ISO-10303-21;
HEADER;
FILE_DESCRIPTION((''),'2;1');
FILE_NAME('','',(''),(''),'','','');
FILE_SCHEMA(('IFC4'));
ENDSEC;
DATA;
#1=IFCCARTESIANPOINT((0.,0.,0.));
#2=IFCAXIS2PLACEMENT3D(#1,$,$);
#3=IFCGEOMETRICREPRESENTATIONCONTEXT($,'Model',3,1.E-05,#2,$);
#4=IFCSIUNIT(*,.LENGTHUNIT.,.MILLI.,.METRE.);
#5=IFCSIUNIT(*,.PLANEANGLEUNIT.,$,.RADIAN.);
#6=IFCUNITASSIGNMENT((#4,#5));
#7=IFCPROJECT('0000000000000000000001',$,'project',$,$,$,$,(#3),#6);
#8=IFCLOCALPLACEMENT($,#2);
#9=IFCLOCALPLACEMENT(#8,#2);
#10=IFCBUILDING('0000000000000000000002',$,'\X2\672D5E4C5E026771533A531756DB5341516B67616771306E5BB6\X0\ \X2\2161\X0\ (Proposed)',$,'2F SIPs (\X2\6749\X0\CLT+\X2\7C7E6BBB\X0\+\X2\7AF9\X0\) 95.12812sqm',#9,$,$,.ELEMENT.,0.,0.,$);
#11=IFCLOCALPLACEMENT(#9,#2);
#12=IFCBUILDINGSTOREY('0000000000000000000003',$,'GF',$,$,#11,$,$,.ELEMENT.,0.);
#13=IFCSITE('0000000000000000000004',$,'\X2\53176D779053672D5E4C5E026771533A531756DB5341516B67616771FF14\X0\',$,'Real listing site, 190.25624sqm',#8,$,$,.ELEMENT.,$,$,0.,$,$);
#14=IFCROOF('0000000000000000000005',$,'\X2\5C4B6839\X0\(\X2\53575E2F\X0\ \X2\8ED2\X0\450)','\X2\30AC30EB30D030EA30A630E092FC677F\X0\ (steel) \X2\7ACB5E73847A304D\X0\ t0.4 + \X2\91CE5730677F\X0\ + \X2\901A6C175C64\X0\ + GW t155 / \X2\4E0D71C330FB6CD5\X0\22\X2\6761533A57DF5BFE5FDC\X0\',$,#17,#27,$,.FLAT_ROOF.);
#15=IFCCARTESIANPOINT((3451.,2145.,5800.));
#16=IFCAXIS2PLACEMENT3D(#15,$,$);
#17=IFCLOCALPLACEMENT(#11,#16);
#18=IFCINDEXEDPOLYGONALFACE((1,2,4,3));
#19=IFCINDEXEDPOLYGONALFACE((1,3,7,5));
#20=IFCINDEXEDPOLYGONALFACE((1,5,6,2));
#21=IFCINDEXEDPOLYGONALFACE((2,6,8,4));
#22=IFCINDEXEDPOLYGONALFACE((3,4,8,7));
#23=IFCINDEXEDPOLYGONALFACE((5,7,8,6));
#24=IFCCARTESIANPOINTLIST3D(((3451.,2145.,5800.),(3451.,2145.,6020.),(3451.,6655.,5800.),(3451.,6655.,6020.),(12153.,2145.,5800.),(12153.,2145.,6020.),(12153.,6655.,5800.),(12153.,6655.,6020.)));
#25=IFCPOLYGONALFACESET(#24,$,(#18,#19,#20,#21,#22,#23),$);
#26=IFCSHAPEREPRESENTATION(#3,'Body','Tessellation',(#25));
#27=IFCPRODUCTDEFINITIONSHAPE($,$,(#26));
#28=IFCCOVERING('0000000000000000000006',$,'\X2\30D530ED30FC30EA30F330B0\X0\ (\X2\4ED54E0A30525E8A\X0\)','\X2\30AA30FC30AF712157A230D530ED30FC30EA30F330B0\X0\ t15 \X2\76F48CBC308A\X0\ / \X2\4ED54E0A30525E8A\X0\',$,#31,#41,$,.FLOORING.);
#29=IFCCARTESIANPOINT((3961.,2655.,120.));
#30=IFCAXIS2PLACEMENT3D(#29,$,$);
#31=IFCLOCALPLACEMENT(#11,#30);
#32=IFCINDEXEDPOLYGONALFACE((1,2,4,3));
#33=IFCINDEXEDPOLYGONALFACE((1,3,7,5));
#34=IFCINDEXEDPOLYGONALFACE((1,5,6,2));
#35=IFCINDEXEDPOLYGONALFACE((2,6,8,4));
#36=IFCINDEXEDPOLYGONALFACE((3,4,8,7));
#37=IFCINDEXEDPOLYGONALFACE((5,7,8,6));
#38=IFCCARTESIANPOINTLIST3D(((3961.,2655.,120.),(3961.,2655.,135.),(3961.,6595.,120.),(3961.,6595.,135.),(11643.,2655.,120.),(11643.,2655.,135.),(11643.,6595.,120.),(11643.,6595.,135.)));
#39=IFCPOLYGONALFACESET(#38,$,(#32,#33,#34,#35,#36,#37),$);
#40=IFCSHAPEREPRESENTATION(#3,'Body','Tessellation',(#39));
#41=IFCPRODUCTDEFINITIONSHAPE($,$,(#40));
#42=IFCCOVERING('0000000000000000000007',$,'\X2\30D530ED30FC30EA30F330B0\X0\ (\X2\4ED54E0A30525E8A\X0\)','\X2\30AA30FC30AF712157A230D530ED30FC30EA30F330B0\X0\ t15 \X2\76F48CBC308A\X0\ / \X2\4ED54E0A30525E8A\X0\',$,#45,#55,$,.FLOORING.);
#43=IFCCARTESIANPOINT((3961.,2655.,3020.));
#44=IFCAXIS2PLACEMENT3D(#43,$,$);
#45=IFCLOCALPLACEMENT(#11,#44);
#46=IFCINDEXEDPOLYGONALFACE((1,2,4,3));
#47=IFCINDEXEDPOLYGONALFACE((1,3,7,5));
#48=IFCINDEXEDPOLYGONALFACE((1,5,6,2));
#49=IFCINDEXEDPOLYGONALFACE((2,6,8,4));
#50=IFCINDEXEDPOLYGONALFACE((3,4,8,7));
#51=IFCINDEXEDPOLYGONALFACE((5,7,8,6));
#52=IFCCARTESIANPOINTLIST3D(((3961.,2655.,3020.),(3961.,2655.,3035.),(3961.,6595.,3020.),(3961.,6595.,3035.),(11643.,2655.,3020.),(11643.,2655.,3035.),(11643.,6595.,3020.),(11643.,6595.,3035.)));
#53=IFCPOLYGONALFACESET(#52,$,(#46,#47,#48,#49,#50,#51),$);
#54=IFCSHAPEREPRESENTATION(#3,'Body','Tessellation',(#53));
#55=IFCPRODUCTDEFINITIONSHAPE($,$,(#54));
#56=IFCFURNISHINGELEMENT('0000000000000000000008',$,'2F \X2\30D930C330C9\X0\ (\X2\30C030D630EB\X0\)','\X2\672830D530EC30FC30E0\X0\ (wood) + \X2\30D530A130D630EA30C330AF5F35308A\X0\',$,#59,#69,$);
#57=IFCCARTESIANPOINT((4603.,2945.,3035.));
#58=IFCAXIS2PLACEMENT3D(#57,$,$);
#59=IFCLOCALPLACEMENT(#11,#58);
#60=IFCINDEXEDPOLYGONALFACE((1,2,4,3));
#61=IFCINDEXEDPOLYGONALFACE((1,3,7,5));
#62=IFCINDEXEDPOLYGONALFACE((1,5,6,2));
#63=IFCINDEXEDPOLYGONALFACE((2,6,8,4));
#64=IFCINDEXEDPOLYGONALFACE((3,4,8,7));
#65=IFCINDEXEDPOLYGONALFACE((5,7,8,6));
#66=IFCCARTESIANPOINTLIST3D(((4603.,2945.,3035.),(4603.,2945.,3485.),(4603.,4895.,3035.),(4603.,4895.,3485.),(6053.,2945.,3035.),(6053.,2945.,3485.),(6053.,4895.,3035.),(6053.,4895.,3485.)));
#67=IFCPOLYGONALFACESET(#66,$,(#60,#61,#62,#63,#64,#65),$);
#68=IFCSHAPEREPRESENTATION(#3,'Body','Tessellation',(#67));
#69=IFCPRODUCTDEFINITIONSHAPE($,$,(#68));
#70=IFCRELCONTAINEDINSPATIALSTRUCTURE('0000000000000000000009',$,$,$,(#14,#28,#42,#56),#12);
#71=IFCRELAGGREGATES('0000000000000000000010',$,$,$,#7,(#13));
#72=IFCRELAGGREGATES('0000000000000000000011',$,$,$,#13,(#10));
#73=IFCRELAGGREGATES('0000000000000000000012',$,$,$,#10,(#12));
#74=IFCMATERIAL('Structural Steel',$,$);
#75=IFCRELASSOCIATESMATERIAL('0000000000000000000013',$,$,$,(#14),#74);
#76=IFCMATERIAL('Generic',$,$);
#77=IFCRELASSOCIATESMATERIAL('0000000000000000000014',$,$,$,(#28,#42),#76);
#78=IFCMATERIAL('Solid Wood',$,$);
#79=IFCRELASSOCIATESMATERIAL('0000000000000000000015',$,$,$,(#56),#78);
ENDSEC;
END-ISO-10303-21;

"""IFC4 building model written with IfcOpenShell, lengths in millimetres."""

from ifc_helpers import new_model, si_unit, frame, frame_2d, origin, place, context, project, spatial, rectangle, extrude, material, element, save


model = new_model("IFC4")

# Units and contexts
model_context = context("Model", 3, precision=1e-05, world=origin())
ifc_project = project(units=[si_unit("LENGTHUNIT", "METRE", prefix="MILLI"), si_unit("PLANEANGLEUNIT", "RADIAN")], contexts=[model_context])

# Site, building, storey
site_placement = place(None, origin())
site = spatial("IfcSite", under=ifc_project, at=site_placement, Name="北海道札幌市東区北四十八条東４", ObjectType="Real listing site, 190.25624sqm", CompositionType="ELEMENT", RefElevation=0.0)
building_placement = place(site_placement, origin())
building = spatial("IfcBuilding", under=site, at=building_placement, Name="札幌市東区北四十八条東の家 Ⅱ (Proposed)", ObjectType="2F SIPs (杉CLT+籾殻+竹) 95.12812sqm", CompositionType="ELEMENT", ElevationOfRefHeight=0.0, ElevationOfTerrain=0.0)
storey_placement = place(building_placement, origin())
storey = spatial("IfcBuildingStorey", under=building, at=storey_placement, Name="GF", CompositionType="ELEMENT", Elevation=0.0)

# Shared definitions
ifc_material_1 = material(Name="Solid Wood")

# Roof
ifc_material_2 = material(Name="Structural Steel")
for number, where, name in (
    (1, (3451.0, 2145.0, 5800.0), "屋根(南帯 軒450)"),
):
    element("IfcRoof", number, at=place(storey_placement, frame(where)), inside=storey, material=ifc_material_2, Name=name, Description="ガルバリウム鋼板 (steel) 立平葺き t0.4 + 野地板 + 通気層 + GW t155 / 不燃・法22条区域対応", PredefinedType="FLAT_ROOF", context=model_context, shape_type="SweptSolid", body=[
        extrude(rectangle(XDim=8702.0, YDim=4510.0, at=frame_2d((4351.0, 2255.0))), frame((3451.0, 2145.0, 5800.0)), (0.0, 0.0, 1.0), 220.0),
    ])

# Coverings
ifc_material_3 = material(Name="Generic")
covering_1_placement = place(storey_placement, frame((3961.0, 2655.0, 120.0)))
element("IfcCovering", 2, at=covering_1_placement, inside=storey, material=ifc_material_3, Name="フローリング (仕上げ床)", Description="オーク無垢フローリング t15 直貼り / 仕上げ床", PredefinedType="FLOORING", context=model_context, shape_type="SweptSolid", body=[
    extrude(rectangle(XDim=7682.0, YDim=3940.0, at=frame_2d((3841.0, 1970.0))), frame((3961.0, 2655.0, 120.0)), (0.0, 0.0, 1.0), 15.0),
])
covering_2_placement = place(storey_placement, frame((3961.0, 2655.0, 3020.0)))
element("IfcCovering", 3, at=covering_2_placement, inside=storey, material=ifc_material_3, Name="フローリング (仕上げ床)", Description="オーク無垢フローリング t15 直貼り / 仕上げ床", PredefinedType="FLOORING", context=model_context, shape_type="SweptSolid", body=[
    extrude(rectangle(XDim=7682.0, YDim=3940.0, at=frame_2d((3841.0, 1970.0))), frame((3961.0, 2655.0, 3020.0)), (0.0, 0.0, 1.0), 15.0),
])

# Furnishing element
furnishing_placement = place(storey_placement, frame((4603.0, 2945.0, 3035.0)))
element("IfcFurnishingElement", 4, at=furnishing_placement, inside=storey, material=ifc_material_1, Name="2F ベッド (ダブル)", Description="木フレーム (wood) + ファブリック張り", context=model_context, shape_type="SweptSolid", body=[
    extrude(rectangle(XDim=1450.0, YDim=1950.0, at=frame_2d((725.0, 975.0))), frame((4603.0, 2945.0, 3035.0)), (0.0, 0.0, 1.0), 450.0),
])

save(model, "model.ifc")
